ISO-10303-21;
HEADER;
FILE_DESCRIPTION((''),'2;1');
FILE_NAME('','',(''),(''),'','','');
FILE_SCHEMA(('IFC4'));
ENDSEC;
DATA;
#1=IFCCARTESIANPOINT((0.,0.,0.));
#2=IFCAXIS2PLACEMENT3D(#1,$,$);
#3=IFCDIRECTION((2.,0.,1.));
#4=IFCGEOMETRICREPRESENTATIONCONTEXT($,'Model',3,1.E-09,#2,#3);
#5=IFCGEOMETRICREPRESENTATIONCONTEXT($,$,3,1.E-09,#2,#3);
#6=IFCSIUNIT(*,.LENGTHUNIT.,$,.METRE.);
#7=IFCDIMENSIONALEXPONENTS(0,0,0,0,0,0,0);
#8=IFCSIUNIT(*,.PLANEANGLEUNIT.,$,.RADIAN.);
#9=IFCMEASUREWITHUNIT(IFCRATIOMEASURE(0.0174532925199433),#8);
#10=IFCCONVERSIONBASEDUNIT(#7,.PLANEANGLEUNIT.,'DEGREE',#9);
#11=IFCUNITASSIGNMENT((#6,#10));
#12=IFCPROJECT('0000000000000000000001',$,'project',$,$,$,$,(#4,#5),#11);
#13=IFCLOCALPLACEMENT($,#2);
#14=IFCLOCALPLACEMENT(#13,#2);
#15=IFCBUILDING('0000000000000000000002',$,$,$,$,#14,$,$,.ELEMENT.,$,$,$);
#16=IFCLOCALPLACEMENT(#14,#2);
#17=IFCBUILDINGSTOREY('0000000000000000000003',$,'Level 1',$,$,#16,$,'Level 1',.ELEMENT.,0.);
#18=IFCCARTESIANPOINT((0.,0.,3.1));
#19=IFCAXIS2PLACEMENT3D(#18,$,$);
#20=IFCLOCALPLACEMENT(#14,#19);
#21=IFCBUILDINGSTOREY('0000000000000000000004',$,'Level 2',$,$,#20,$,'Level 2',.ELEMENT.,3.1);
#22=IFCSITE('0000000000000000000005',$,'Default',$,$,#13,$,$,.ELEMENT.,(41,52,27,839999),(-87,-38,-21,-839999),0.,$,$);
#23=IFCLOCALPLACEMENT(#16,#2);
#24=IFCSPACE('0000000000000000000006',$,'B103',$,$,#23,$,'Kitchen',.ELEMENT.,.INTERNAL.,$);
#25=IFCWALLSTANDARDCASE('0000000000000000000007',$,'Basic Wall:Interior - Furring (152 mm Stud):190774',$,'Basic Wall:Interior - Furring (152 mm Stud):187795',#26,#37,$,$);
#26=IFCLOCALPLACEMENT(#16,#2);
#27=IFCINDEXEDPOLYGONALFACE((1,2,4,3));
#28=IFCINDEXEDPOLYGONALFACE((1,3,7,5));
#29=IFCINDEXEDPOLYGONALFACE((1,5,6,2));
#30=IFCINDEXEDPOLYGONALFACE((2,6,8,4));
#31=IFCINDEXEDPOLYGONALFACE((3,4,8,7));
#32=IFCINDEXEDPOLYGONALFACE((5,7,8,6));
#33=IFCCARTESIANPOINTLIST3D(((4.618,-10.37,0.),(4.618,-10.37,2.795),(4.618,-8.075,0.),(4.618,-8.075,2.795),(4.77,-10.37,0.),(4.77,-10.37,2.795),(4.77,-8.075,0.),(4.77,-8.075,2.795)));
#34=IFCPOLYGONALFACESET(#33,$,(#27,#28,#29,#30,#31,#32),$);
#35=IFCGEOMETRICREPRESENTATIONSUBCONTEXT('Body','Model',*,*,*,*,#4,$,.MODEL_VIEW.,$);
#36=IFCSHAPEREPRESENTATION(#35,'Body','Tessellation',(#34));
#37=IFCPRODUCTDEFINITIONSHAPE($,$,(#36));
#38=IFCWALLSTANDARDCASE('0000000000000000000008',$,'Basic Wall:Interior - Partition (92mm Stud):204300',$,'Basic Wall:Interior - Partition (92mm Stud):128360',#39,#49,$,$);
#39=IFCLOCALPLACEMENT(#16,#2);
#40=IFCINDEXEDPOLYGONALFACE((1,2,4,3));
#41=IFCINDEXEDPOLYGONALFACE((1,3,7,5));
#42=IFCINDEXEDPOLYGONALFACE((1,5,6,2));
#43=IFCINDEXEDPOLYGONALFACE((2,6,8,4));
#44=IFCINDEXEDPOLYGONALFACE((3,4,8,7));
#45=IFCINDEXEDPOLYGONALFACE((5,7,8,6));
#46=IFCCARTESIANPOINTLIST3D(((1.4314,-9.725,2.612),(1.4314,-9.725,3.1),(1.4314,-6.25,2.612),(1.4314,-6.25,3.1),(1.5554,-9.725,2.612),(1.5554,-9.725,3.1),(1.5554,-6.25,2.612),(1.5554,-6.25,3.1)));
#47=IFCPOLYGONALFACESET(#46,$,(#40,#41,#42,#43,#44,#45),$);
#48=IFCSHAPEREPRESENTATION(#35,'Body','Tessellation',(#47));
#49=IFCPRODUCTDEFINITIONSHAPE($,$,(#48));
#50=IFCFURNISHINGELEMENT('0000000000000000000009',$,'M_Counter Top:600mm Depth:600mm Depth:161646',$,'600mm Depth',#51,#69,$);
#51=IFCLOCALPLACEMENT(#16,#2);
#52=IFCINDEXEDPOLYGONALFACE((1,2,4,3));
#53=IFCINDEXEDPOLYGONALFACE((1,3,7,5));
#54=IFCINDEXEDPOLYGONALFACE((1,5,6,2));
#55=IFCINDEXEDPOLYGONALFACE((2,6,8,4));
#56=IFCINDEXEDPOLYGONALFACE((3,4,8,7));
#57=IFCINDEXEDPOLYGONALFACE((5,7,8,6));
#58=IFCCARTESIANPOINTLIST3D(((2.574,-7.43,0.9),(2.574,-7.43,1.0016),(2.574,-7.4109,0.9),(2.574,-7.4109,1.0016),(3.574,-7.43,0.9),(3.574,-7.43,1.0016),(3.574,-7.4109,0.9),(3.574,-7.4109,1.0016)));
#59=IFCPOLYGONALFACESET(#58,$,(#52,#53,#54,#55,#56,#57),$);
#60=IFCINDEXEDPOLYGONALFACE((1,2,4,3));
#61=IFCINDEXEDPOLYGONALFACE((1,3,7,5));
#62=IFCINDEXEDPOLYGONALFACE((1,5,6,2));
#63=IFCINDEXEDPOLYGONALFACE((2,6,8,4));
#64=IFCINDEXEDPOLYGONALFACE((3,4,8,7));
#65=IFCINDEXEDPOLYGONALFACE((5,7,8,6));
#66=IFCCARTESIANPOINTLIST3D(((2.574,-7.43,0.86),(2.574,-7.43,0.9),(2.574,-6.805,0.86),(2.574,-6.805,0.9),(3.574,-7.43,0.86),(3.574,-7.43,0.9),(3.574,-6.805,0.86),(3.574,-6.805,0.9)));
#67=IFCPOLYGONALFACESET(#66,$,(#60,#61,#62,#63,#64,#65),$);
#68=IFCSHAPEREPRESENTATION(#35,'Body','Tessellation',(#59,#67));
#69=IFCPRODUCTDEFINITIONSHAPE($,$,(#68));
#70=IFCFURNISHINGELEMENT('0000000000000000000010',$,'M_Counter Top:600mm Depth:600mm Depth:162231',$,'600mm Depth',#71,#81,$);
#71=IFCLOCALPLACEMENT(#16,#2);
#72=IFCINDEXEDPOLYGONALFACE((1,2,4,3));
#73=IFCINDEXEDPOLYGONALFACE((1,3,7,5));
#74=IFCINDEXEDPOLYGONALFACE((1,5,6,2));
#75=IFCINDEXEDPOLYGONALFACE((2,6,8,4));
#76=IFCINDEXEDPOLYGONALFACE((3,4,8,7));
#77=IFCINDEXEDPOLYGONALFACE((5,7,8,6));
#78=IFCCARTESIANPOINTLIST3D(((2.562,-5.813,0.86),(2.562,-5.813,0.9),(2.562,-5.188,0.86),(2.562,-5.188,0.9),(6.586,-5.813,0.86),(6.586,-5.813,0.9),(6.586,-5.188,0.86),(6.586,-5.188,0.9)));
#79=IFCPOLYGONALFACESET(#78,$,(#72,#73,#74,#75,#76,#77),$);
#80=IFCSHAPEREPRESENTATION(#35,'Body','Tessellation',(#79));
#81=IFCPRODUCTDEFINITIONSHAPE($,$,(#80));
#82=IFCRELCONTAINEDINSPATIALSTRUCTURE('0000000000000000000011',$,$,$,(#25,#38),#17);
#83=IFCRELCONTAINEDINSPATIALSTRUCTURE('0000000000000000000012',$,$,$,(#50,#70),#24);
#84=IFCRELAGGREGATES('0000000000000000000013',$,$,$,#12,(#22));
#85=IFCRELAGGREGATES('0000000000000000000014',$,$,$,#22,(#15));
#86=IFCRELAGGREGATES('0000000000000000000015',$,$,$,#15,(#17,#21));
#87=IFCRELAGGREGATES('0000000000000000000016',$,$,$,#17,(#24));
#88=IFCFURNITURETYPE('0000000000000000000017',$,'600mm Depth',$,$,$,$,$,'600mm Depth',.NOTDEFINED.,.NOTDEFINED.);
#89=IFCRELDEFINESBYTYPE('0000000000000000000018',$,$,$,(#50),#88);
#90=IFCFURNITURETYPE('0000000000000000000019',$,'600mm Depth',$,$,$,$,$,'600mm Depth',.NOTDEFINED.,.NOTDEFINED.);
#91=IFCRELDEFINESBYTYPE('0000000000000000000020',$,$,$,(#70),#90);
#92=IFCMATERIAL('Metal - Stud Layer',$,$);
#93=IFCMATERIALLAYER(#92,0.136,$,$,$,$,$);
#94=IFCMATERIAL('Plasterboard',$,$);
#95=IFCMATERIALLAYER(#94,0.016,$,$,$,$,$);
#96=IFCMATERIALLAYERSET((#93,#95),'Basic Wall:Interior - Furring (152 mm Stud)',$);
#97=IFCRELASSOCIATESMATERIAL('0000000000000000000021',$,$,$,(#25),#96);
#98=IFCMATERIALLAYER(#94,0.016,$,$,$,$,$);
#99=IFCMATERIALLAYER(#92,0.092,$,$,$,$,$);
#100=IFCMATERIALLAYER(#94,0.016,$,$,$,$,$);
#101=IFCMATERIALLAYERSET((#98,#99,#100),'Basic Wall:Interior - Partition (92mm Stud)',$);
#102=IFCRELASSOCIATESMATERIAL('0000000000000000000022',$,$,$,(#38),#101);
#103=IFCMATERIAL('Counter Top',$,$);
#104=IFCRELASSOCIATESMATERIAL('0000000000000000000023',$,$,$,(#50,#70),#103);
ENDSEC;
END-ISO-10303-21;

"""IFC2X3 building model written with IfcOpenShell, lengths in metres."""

from ifc_helpers import new_model, entity, si_unit, converted_unit, direction, frame, frame_2d, origin, place, context, subcontext, project, spatial, rectangle, extrude, source, transform, mapped, material, layer, layer_set, layer_usage, type_object, type_shapes, element, save


model = new_model("IFC2X3")

# Units and contexts
model_context = context("Model", 3, precision=1e-09, world=origin(), true_north=direction((2.0, 0.0, 1.0)))
context_of_model = context(None, 3, precision=1e-09, world=origin(), true_north=direction((2.0, 0.0, 1.0)))
body_context = subcontext(model_context, "Body", "Model", "MODEL_VIEW")
ifc_project = project(units=[si_unit("LENGTHUNIT", "METRE"), converted_unit("PLANEANGLEUNIT", "DEGREE", entity("IfcRatioMeasure", 0.0174532925199433), si_unit("PLANEANGLEUNIT", "RADIAN"), dimensions=[0, 0, 0, 0, 0, 0, 0])], contexts=[model_context, context_of_model])

# Site, building, storey
site_placement = place(None, origin())
site = spatial("IfcSite", under=ifc_project, at=site_placement, Name="Default", CompositionType="ELEMENT", RefLatitude=(41, 52, 27, 839999), RefLongitude=(-87, -38, -21, -839999), RefElevation=0.0)
building_placement = place(site_placement, origin())
building = spatial("IfcBuilding", under=site, at=building_placement, CompositionType="ELEMENT")
storey_1_placement = place(building_placement, origin())
storey_1 = spatial("IfcBuildingStorey", under=building, at=storey_1_placement, Name="Level 1", LongName="Level 1", CompositionType="ELEMENT", Elevation=0.0)

# Shared definitions
ifc_material_1 = material(Name="Plasterboard")
ifc_layer_1 = layer(ifc_material_1, 0.016)
ifc_material_2 = material(Name="Metal - Stud Layer")
ifc_layer_2 = layer(ifc_material_2, 0.092)
ifc_layer_3 = layer(ifc_material_1, 0.016)
ifc_layer_set_1 = layer_set([ifc_layer_1, ifc_layer_2, ifc_layer_3], Name="Basic Wall:Interior - Partition (92mm Stud)")

# Shared definitions
storey_2_placement = place(building_placement, frame((0.0, 0.0, 3.1)))
storey_2 = spatial("IfcBuildingStorey", under=building, at=storey_2_placement, Name="Level 2", LongName="Level 2", CompositionType="ELEMENT", Elevation=3.1)

# Walls
ifc_layer_4 = layer(ifc_material_2, 0.136)
ifc_layer_5 = layer(ifc_material_1, 0.016)
ifc_layer_set_2 = layer_set([ifc_layer_4, ifc_layer_5], Name="Basic Wall:Interior - Furring (152 mm Stud)")
ifc_layer_usage_1 = layer_usage(ifc_layer_set_2, "AXIS2", "POSITIVE", -0.076)
wall_1_placement = place(storey_1_placement, frame((4.694, -8.075, 0.0), z_axis=(0.0, 0.0, 1.0), x_axis=(0.0, -1.0, 0.0)))
element("IfcWallStandardCase", 1, at=wall_1_placement, inside=storey_1, material=ifc_layer_usage_1, Name="Basic Wall:Interior - Furring (152 mm Stud):190774", ObjectType="Basic Wall:Interior - Furring (152 mm Stud):187795", context=body_context, shape_type="SweptSolid", body=[
    extrude(rectangle(XDim=2.295, YDim=0.152, at=frame_2d((1.1475, 0.0), x_axis=(-1.0, 0.0))), origin(), (0.0, 0.0, 1.0), 2.795),
])
ifc_layer_usage_2 = layer_usage(ifc_layer_set_1, "AXIS2", "NEGATIVE", 0.062)
wall_2_placement = place(storey_1_placement, frame((1.4934, -6.25, 2.612), z_axis=(0.0, 0.0, 1.0), x_axis=(0.0, -1.0, 0.0)))
element("IfcWallStandardCase", 2, at=wall_2_placement, inside=storey_1, material=ifc_layer_usage_2, Name="Basic Wall:Interior - Partition (92mm Stud):204300", ObjectType="Basic Wall:Interior - Partition (92mm Stud):128360", context=body_context, shape_type="SweptSolid", body=[
    extrude(rectangle(XDim=3.475, YDim=0.124, at=frame_2d((1.7375, 0.0), x_axis=(-1.0, 0.0))), origin(), (0.0, 0.0, 1.0), 0.488),
])

# Shared definitions
space_1_placement = place(storey_1_placement, origin())
space_1 = spatial("IfcSpace", under=storey_1, at=space_1_placement, Name="B103", LongName="Kitchen", CompositionType="ELEMENT", InteriorOrExteriorSpace="INTERNAL")

# Shared definitions
ifc_material_3 = material(Name="Counter Top")

# Furnishing elements
furniture_type_1 = type_object("IfcFurnitureType", Name="600mm Depth", ElementType="600mm Depth", AssemblyPlace="NOTDEFINED")
shared_shape_1 = source(origin(), body_context, "Body", "SweptSolid", [
    extrude(rectangle(XDim=0.0191, YDim=1.0, at=frame_2d((0.0, 0.0), x_axis=(1.0, 0.0))), frame((-0.7005, -0.0095, 0.9), z_axis=(0.0, 0.0, 1.0), x_axis=(0.0, -1.0, 0.0)), (0.0, 0.0, 1.0), 0.1016),
    extrude(rectangle(XDim=1.0, YDim=0.625, at=frame_2d((0.0, 0.0), x_axis=(1.0, 0.0))), frame((-0.7005, -0.3125, 0.86), z_axis=(0.0, 0.0, 1.0), x_axis=(-1.0, 0.0, 0.0)), (0.0, 0.0, 1.0), 0.04),
])
type_shapes(furniture_type_1, [shared_shape_1])
furnishing_1_placement = place(space_1_placement, frame((2.3735, -7.43, 0.0), z_axis=(0.0, 0.0, 1.0), x_axis=(-1.0, 0.0, 0.0)))
element("IfcFurnishingElement", 3, at=furnishing_1_placement, inside=space_1, type_object=furniture_type_1, material=ifc_material_3, Name="M_Counter Top:600mm Depth:600mm Depth:161646", ObjectType="600mm Depth", context=body_context, shape_type="MappedRepresentation", body=[
    mapped(shared_shape_1, transform((0.0, 0.0, 0.0), scale=1.0)),
])
furniture_type_2 = type_object("IfcFurnitureType", Name="600mm Depth", ElementType="600mm Depth", AssemblyPlace="NOTDEFINED")
shared_shape_2 = source(origin(), body_context, "Body", "SweptSolid", [
    extrude(rectangle(XDim=4.024, YDim=0.625, at=frame_2d((0.0, 0.0), x_axis=(1.0, 0.0))), frame((0.8115, -0.3125, 0.86), z_axis=(0.0, 0.0, 1.0), x_axis=(-1.0, 0.0, 0.0)), (0.0, 0.0, 1.0), 0.04),
])
type_shapes(furniture_type_2, [shared_shape_2])
furnishing_2_placement = place(space_1_placement, frame((3.7625, -5.188, 0.0)))
element("IfcFurnishingElement", 4, at=furnishing_2_placement, inside=space_1, type_object=furniture_type_2, material=ifc_material_3, Name="M_Counter Top:600mm Depth:600mm Depth:162231", ObjectType="600mm Depth", context=body_context, shape_type="MappedRepresentation", body=[
    mapped(shared_shape_2, transform((0.0, 0.0, 0.0), scale=1.0)),
])

save(model, "model.ifc")
